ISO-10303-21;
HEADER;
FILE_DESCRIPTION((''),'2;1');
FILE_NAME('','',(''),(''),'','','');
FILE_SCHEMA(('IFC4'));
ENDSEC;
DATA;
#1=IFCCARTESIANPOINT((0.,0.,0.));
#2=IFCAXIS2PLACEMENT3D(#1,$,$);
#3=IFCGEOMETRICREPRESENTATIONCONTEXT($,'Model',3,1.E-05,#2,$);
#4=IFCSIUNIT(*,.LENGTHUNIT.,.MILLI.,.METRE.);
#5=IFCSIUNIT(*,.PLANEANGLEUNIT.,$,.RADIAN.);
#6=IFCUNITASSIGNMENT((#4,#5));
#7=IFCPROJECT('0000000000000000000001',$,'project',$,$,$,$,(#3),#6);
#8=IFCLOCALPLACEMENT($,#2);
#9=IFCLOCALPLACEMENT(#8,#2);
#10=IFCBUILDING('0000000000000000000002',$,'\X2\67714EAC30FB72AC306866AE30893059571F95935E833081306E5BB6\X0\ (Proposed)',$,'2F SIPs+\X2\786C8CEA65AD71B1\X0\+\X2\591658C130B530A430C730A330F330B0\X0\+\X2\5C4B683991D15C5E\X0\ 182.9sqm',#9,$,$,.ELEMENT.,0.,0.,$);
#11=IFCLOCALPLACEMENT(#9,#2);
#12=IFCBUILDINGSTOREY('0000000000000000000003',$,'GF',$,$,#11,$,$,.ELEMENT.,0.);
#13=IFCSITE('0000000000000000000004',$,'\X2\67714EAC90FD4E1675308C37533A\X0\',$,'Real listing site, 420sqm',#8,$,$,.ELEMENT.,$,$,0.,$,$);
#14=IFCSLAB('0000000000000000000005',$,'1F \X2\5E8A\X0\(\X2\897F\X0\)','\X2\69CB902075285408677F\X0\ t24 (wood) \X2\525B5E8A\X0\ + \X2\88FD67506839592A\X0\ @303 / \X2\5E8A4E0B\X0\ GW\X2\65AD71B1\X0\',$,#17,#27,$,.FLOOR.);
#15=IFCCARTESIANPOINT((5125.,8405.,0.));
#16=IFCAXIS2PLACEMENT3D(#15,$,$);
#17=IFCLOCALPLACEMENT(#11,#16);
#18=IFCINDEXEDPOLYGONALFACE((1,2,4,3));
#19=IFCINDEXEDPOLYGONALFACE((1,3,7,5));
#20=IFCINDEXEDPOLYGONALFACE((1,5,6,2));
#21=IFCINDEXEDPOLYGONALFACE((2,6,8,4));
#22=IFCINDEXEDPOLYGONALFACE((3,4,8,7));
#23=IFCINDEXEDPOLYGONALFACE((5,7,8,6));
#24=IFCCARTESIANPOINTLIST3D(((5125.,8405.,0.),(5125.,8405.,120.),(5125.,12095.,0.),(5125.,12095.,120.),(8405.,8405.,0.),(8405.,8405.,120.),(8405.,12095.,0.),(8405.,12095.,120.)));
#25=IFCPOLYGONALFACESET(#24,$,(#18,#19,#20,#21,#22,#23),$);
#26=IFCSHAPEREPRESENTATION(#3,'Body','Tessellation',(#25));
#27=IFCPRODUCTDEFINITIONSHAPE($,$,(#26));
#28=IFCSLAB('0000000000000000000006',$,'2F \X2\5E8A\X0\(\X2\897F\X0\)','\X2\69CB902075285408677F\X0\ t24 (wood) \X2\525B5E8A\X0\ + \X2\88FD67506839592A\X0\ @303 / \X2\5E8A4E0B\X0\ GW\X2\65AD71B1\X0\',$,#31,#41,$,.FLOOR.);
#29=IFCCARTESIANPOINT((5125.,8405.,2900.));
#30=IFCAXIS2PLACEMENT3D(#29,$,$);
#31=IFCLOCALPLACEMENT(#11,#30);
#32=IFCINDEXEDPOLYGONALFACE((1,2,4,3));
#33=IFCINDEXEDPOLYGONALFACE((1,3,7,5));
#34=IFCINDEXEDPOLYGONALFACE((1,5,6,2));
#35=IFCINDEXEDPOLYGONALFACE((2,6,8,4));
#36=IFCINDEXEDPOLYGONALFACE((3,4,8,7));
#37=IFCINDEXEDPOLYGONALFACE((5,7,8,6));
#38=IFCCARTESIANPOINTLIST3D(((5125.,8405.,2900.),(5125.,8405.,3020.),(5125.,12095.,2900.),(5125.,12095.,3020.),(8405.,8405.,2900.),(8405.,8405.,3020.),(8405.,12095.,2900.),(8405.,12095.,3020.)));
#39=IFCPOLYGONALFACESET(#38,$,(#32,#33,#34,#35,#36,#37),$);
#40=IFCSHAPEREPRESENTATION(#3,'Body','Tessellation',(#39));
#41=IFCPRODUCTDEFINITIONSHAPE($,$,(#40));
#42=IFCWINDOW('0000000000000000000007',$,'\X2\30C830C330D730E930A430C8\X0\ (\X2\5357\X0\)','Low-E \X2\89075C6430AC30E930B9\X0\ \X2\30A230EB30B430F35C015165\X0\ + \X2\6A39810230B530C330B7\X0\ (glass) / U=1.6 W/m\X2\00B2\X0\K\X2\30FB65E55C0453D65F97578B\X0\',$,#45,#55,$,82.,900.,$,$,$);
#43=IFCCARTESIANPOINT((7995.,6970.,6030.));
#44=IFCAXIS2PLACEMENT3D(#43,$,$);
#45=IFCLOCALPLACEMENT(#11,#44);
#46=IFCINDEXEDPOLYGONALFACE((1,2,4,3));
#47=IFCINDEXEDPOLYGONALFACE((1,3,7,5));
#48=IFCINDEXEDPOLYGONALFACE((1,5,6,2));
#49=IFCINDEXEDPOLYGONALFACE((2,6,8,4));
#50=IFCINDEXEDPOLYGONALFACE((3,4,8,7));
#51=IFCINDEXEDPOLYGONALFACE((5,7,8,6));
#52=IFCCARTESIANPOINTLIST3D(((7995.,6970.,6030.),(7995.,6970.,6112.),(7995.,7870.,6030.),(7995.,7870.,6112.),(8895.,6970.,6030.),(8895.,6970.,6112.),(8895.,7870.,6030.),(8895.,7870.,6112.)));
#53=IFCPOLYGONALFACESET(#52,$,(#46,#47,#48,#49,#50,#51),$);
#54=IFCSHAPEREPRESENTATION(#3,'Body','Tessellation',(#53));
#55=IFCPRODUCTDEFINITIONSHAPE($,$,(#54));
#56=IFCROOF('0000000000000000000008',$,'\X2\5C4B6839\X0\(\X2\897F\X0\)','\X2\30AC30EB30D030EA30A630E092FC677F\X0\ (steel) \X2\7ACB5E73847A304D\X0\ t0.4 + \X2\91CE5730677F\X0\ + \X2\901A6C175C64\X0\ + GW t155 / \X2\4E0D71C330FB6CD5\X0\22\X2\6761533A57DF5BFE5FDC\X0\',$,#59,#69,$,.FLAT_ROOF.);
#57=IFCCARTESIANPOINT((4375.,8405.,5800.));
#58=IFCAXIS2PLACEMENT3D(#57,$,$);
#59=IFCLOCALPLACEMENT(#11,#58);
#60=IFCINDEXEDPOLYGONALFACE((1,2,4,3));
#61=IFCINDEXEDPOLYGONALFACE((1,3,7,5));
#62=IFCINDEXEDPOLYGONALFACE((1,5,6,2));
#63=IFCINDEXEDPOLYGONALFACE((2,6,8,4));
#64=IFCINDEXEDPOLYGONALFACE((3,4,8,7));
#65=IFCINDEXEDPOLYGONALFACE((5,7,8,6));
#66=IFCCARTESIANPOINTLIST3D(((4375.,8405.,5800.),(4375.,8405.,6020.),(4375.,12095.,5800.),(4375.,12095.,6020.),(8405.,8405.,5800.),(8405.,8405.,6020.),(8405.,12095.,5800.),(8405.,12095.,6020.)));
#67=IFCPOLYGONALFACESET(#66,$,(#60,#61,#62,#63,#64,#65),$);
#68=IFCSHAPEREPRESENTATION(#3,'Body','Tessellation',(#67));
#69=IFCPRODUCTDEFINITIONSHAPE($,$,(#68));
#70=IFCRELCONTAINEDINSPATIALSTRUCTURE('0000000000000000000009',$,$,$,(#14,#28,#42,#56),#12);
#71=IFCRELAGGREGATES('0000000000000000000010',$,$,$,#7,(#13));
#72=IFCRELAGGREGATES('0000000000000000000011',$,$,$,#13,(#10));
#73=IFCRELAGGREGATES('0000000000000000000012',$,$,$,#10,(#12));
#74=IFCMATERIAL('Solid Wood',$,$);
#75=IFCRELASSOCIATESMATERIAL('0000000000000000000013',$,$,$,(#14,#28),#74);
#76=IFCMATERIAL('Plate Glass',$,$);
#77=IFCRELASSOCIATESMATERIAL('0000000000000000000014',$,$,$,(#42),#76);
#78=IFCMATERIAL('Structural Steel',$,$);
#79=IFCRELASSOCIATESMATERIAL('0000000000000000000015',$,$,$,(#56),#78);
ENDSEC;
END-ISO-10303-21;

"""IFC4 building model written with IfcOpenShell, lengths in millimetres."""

from ifc_helpers import new_model, si_unit, frame, frame_2d, origin, place, context, project, spatial, rectangle, extrude, material, element, save


model = new_model("IFC4")

# Units and contexts
model_context = context("Model", 3, precision=1e-05, world=origin())
ifc_project = project(units=[si_unit("LENGTHUNIT", "METRE", prefix="MILLI"), si_unit("PLANEANGLEUNIT", "RADIAN")], contexts=[model_context])

# Site, building, storey
site_placement = place(None, origin())
site = spatial("IfcSite", under=ifc_project, at=site_placement, Name="東京都世田谷区", ObjectType="Real listing site, 420sqm", CompositionType="ELEMENT", RefElevation=0.0)
building_placement = place(site_placement, origin())
building = spatial("IfcBuilding", under=site, at=building_placement, Name="東京・犬と暮らす土間広めの家 (Proposed)", ObjectType="2F SIPs+硬質断熱+外壁サイディング+屋根金属 182.9sqm", CompositionType="ELEMENT", ElevationOfRefHeight=0.0, ElevationOfTerrain=0.0)
storey_placement = place(building_placement, origin())
storey = spatial("IfcBuildingStorey", under=building, at=storey_placement, Name="GF", CompositionType="ELEMENT", Elevation=0.0)

# Shared definitions
ifc_material_1 = material(Name="Solid Wood")

# Slabs
slab_1_placement = place(storey_placement, frame((5125.0, 8405.0, 0.0)))
element("IfcSlab", 1, at=slab_1_placement, inside=storey, material=ifc_material_1, Name="1F 床(西)", Description="構造用合板 t24 (wood) 剛床 + 製材根太 @303 / 床下 GW断熱", PredefinedType="FLOOR", context=model_context, shape_type="SweptSolid", body=[
    extrude(rectangle(XDim=3280.0, YDim=3690.0, at=frame_2d((1640.0, 1845.0))), frame((5125.0, 8405.0, 0.0)), (0.0, 0.0, 1.0), 120.0),
])
slab_2_placement = place(storey_placement, frame((5125.0, 8405.0, 2900.0)))
element("IfcSlab", 2, at=slab_2_placement, inside=storey, material=ifc_material_1, Name="2F 床(西)", Description="構造用合板 t24 (wood) 剛床 + 製材根太 @303 / 床下 GW断熱", PredefinedType="FLOOR", context=model_context, shape_type="SweptSolid", body=[
    extrude(rectangle(XDim=3280.0, YDim=3690.0, at=frame_2d((1640.0, 1845.0))), frame((5125.0, 8405.0, 2900.0)), (0.0, 0.0, 1.0), 120.0),
])

# Window
ifc_material_2 = material(Name="Plate Glass")
window_placement = place(storey_placement, frame((7995.0, 6970.0, 6030.0)))
element("IfcWindow", 3, at=window_placement, inside=storey, material=ifc_material_2, Name="トップライト (南)", Description="Low-E 複層ガラス アルゴン封入 + 樹脂サッシ (glass) / U=1.6 W/m²K・日射取得型", OverallHeight=82.0, OverallWidth=900.0, context=model_context, shape_type="SweptSolid", body=[
    extrude(rectangle(XDim=900.0, YDim=900.0, at=frame_2d((450.0, 450.0))), frame((7995.0, 6970.0, 6030.0)), (0.0, 0.0, 1.0), 82.0),
])

# Roof
ifc_material_3 = material(Name="Structural Steel")
for number, where, name in (
    (4, (4375.0, 8405.0, 5800.0), "屋根(西)"),
):
    element("IfcRoof", number, at=place(storey_placement, frame(where)), inside=storey, material=ifc_material_3, Name=name, Description="ガルバリウム鋼板 (steel) 立平葺き t0.4 + 野地板 + 通気層 + GW t155 / 不燃・法22条区域対応", PredefinedType="FLAT_ROOF", context=model_context, shape_type="SweptSolid", body=[
        extrude(rectangle(XDim=4030.0, YDim=3690.0, at=frame_2d((2015.0, 1845.0))), frame((4375.0, 8405.0, 5800.0)), (0.0, 0.0, 1.0), 220.0),
    ])

save(model, "model.ifc")
